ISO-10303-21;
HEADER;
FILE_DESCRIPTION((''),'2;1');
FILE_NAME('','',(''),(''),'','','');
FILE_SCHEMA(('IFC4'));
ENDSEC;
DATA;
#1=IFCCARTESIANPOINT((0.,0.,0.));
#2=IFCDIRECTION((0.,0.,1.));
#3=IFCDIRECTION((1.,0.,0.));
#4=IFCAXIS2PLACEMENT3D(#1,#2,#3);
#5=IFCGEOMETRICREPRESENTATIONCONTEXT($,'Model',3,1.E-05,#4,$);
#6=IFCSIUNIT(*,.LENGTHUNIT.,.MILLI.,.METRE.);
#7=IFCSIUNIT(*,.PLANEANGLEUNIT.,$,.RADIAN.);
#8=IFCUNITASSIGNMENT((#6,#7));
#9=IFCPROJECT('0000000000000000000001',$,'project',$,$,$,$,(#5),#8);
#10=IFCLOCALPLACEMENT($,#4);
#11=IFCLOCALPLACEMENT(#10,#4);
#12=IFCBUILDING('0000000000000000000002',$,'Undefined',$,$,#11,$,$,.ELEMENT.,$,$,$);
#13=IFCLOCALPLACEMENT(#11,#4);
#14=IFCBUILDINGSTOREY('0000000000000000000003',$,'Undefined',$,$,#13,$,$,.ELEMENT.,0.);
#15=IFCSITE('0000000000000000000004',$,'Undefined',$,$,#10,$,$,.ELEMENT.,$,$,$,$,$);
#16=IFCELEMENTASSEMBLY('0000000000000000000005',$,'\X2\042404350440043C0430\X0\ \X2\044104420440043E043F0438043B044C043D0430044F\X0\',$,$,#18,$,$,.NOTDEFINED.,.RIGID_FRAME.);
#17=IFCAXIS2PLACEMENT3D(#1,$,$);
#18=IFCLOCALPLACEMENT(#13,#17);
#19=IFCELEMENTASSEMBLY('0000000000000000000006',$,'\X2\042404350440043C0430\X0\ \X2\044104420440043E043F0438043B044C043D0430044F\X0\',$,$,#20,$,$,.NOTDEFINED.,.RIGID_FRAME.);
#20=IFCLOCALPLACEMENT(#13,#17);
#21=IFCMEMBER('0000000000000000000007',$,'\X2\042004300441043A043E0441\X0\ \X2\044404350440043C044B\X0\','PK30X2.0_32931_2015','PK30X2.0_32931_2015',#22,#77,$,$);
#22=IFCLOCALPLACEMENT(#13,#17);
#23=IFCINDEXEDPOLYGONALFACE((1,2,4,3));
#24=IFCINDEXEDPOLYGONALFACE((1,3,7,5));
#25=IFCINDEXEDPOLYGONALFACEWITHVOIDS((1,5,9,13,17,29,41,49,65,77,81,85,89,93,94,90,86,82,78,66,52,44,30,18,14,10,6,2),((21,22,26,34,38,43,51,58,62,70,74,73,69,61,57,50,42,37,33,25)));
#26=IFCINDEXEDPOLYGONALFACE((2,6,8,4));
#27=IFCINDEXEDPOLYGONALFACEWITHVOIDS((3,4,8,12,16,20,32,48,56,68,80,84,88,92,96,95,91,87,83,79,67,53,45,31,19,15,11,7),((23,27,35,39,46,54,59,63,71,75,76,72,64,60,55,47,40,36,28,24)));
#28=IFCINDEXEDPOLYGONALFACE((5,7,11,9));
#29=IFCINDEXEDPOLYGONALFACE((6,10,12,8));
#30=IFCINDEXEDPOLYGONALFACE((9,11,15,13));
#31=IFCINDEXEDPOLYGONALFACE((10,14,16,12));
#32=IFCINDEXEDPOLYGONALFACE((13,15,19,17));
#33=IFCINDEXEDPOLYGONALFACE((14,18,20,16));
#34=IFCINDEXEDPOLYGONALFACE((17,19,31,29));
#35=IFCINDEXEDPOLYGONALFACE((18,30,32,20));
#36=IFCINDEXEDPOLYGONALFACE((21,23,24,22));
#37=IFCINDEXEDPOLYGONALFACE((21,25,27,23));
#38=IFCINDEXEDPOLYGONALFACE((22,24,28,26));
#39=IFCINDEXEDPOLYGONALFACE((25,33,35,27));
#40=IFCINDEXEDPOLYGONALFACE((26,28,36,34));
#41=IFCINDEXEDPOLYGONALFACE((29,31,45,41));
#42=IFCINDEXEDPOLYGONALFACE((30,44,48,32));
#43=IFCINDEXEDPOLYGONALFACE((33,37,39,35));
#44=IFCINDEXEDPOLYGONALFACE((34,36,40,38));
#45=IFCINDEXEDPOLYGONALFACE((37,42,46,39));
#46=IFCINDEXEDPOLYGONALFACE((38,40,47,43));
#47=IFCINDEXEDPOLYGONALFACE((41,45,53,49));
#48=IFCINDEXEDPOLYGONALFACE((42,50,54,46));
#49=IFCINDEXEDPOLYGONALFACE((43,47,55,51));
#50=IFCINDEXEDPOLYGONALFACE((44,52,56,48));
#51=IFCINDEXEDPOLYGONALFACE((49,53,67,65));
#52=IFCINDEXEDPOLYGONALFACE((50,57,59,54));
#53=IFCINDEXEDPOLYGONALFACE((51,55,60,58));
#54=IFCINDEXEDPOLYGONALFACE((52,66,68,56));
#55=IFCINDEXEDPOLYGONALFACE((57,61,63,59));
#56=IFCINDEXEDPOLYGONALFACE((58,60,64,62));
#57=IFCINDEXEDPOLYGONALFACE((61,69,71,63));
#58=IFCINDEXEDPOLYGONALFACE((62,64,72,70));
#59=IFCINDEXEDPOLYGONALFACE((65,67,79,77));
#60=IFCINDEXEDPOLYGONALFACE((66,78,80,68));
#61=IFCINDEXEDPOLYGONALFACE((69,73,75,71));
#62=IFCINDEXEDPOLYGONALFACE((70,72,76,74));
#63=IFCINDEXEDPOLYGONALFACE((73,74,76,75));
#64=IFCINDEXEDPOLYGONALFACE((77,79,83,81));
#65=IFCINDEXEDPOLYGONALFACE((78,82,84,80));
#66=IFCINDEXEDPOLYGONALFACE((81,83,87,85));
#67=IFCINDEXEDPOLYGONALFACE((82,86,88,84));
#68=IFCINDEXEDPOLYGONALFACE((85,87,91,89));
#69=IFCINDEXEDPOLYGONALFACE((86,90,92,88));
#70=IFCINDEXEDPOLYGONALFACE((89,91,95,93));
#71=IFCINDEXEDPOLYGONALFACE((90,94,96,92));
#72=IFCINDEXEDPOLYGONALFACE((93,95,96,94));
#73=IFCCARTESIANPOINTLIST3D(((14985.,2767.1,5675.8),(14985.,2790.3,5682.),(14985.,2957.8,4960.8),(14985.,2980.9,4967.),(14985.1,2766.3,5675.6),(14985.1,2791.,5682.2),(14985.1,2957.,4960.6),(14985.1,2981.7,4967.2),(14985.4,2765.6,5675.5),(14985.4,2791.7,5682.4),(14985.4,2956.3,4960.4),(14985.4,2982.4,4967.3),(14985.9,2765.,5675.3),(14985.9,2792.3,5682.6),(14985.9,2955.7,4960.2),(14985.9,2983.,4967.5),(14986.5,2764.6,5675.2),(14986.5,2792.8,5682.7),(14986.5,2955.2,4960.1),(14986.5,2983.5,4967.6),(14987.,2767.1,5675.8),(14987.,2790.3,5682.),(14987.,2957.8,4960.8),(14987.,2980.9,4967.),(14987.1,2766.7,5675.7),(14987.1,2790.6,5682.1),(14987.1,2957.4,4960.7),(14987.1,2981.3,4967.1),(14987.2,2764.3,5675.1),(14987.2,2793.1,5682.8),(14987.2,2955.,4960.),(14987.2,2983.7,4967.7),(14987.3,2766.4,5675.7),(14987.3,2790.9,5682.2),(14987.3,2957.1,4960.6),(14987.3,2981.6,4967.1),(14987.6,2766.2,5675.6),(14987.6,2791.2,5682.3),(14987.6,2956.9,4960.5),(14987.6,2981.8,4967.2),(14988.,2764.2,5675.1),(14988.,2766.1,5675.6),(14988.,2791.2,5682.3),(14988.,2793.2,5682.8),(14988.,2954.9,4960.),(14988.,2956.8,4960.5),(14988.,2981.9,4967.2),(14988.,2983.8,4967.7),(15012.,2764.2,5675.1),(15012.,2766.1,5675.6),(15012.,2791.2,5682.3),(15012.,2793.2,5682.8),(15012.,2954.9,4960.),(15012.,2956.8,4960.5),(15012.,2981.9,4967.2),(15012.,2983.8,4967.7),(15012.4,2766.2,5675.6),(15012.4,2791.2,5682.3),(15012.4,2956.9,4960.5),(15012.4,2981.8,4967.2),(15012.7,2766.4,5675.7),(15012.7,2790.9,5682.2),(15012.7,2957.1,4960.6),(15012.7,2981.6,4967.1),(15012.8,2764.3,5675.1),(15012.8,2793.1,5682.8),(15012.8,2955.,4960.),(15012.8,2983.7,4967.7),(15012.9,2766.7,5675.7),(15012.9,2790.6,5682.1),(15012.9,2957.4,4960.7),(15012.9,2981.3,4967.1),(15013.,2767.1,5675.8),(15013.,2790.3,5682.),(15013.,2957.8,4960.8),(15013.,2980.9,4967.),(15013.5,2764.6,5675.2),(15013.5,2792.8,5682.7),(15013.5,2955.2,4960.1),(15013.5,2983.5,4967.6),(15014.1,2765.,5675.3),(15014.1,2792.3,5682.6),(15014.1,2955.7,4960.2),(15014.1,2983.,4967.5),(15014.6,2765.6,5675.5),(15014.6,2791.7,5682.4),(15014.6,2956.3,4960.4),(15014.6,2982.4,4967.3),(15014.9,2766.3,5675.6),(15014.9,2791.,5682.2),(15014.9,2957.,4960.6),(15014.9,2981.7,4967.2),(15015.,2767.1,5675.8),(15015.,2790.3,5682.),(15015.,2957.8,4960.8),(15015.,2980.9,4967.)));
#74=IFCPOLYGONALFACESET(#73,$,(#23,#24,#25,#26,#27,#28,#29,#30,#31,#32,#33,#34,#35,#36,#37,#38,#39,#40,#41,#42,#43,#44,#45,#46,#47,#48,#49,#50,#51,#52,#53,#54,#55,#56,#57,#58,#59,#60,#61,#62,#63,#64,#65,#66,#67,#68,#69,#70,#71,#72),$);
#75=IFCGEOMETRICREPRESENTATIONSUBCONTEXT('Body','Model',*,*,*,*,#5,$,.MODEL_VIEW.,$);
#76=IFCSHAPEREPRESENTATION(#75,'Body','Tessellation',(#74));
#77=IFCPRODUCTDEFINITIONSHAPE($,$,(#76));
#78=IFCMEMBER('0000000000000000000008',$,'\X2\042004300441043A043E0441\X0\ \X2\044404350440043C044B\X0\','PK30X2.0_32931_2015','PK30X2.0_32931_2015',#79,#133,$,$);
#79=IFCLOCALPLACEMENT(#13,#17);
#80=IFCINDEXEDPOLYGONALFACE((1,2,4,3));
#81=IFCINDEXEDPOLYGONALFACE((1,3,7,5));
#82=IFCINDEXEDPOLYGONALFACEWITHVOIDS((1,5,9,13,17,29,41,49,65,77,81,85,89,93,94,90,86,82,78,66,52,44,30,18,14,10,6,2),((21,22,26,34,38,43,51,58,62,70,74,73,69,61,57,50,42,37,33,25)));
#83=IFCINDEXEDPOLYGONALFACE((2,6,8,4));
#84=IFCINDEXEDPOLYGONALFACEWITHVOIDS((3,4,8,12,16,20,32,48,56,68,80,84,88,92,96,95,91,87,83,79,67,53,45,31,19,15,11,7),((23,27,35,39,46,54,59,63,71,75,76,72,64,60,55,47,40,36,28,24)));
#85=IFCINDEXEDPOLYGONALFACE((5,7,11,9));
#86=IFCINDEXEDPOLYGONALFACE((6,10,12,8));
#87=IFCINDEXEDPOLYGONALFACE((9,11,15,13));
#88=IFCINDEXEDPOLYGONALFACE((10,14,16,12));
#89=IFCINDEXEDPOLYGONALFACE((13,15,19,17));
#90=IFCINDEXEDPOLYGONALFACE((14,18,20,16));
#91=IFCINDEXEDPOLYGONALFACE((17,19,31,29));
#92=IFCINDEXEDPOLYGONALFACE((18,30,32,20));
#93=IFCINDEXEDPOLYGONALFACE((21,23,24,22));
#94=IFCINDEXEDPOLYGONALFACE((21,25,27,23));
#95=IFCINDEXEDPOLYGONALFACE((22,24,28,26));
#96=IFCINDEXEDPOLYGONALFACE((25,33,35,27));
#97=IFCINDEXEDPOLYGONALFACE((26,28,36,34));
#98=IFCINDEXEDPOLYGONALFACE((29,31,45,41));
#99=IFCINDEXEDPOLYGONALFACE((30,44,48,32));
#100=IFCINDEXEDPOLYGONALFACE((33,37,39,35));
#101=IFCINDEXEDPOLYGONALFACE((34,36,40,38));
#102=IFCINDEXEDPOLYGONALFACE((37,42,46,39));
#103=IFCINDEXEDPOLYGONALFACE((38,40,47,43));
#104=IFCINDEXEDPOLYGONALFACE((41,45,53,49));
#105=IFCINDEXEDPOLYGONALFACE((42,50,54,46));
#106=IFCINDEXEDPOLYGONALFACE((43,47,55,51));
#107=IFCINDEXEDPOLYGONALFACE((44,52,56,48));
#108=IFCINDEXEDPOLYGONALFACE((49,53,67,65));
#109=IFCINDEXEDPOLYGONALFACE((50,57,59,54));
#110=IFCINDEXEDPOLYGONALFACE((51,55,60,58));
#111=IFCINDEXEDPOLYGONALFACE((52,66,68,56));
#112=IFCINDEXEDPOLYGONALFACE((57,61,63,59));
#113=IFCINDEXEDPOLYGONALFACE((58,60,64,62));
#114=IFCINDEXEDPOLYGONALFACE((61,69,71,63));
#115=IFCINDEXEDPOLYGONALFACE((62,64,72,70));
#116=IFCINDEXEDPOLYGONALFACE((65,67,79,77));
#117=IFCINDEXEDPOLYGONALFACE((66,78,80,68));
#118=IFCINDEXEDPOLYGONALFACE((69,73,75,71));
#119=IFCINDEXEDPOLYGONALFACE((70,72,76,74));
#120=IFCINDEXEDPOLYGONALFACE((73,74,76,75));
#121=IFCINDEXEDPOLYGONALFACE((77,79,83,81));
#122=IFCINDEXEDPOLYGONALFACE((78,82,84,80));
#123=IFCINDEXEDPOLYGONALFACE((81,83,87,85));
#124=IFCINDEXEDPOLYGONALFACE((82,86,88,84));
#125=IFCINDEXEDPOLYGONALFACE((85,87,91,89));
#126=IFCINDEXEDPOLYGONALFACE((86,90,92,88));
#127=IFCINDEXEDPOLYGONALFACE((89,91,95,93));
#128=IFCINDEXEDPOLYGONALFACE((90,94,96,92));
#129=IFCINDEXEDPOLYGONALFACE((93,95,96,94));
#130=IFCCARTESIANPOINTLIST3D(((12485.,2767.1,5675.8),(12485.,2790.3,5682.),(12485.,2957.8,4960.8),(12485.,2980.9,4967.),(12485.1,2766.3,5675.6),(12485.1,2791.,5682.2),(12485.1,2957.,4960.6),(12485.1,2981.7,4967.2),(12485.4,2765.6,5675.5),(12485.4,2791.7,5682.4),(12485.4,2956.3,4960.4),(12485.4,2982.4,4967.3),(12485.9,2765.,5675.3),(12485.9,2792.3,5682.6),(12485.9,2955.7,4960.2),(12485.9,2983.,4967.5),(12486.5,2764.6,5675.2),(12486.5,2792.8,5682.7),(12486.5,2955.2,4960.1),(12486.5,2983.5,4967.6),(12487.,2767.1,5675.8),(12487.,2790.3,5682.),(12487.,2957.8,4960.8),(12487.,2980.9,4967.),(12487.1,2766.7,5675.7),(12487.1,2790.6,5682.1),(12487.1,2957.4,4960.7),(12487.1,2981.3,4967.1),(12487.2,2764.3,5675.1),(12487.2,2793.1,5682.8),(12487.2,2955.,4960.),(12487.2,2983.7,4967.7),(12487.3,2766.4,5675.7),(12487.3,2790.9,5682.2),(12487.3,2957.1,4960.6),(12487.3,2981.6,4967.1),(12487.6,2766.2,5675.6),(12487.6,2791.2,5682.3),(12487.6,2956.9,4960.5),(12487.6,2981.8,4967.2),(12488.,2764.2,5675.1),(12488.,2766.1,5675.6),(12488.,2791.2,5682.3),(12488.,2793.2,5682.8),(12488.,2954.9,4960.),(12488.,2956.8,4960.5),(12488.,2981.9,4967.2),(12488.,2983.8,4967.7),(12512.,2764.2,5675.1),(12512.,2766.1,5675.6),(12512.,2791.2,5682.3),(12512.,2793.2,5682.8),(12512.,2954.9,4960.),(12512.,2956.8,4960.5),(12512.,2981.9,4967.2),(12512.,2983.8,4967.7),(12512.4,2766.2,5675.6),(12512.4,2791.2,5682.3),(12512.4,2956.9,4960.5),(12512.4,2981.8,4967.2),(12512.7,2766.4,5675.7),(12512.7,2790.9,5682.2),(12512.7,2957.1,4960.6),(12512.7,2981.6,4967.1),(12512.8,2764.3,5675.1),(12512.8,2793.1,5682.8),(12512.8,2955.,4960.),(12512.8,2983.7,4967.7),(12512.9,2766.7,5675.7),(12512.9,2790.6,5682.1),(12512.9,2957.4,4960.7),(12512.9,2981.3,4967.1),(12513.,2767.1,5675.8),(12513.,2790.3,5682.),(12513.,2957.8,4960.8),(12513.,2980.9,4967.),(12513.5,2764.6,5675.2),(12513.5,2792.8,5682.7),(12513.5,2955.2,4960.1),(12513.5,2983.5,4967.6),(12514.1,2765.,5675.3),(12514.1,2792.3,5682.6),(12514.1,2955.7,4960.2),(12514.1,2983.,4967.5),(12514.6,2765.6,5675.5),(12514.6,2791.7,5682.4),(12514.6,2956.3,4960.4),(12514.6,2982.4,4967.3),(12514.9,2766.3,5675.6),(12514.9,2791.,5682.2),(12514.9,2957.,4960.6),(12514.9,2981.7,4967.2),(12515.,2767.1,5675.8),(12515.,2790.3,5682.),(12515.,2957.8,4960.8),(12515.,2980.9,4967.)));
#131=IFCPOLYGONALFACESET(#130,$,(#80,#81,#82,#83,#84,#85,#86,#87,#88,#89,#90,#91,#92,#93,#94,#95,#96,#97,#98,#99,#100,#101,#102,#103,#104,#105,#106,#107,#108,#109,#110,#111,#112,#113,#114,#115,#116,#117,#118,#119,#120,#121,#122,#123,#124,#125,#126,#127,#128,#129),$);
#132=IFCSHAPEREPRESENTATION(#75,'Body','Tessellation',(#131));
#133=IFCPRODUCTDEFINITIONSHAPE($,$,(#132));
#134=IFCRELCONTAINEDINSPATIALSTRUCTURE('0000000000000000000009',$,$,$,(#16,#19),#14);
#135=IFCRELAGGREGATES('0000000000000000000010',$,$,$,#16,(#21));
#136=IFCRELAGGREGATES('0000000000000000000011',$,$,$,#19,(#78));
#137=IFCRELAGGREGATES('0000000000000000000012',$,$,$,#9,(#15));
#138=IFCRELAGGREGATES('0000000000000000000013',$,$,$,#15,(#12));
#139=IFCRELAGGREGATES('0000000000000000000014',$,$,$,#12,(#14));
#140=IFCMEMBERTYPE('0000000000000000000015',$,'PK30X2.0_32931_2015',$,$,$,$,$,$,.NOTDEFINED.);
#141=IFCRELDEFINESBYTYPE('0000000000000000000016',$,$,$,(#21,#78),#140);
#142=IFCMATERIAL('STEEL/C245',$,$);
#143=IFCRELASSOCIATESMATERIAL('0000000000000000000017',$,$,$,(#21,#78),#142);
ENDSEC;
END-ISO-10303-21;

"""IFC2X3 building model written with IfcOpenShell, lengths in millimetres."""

from ifc_helpers import new_model, si_unit, frame, origin_with_axes, origin_2d_with_axis, place, context, subcontext, project, spatial, hollow_rectangle, extrude, material, type_object, element, aggregate, save


model = new_model("IFC2X3")

# Units and contexts
model_context = context("Model", 3, precision=1e-05, world=origin_with_axes())
body_context = subcontext(model_context, "Body", "Model", "MODEL_VIEW")
ifc_project = project(units=[si_unit("LENGTHUNIT", "METRE", prefix="MILLI"), si_unit("PLANEANGLEUNIT", "RADIAN")], contexts=[model_context])

# Site, building, storey
site_placement = place(None, origin_with_axes())
site = spatial("IfcSite", under=ifc_project, at=site_placement, Name="Undefined", CompositionType="ELEMENT")
building_placement = place(site_placement, origin_with_axes())
building = spatial("IfcBuilding", under=site, at=building_placement, Name="Undefined", CompositionType="ELEMENT")
storey_placement = place(building_placement, origin_with_axes())
storey = spatial("IfcBuildingStorey", under=building, at=storey_placement, Name="Undefined", CompositionType="ELEMENT", Elevation=0.0)

# Shared definitions
ifc_material_1 = material(Name="STEEL/C245")

# Element assemblies
assembly_1_placement = place(storey_placement, origin_with_axes())
assembly_1 = element("IfcElementAssembly", 1, at=assembly_1_placement, inside=storey, Name="Ферма стропильная", AssemblyPlace="NOTDEFINED", PredefinedType="RIGID_FRAME")
assembly_2_placement = place(storey_placement, origin_with_axes())
assembly_2 = element("IfcElementAssembly", 2, at=assembly_2_placement, inside=storey, Name="Ферма стропильная", AssemblyPlace="NOTDEFINED", PredefinedType="RIGID_FRAME")

# Members
member_type_1 = type_object("IfcMemberType", Name="PK30X2.0_32931_2015", PredefinedType="NOTDEFINED")
member_1_placement = place(assembly_1_placement, frame((15000.0, 2778.7, 5678.9), z_axis=(0.0, -0.966235, -0.257663), x_axis=(0.0, 0.257663, -0.966235)))
member_1 = element("IfcMember", 3, at=member_1_placement, type_object=member_type_1, material=ifc_material_1, Name="Раскос фермы", Description="PK30X2.0_32931_2015", ObjectType="PK30X2.0_32931_2015", context=body_context, shape_type="SweptSolid", body=[
    extrude(hollow_rectangle(XDim=30.0, YDim=30.0, WallThickness=2.0, InnerFilletRadius=1.0, OuterFilletRadius=3.0, at=origin_2d_with_axis()), frame((740.0, 0.0, 0.0), z_axis=(-1.0, 0.0, 0.0), x_axis=(0.0, -1.0, 0.0)), (0.0, 0.0, 1.0), 740.0),
])
aggregate(assembly_1, [member_1])
member_2_placement = place(assembly_2_placement, frame((12500.0, 2778.7, 5678.9), z_axis=(0.0, -0.966235, -0.257663), x_axis=(0.0, 0.257663, -0.966235)))
member_2 = element("IfcMember", 4, at=member_2_placement, type_object=member_type_1, material=ifc_material_1, Name="Раскос фермы", Description="PK30X2.0_32931_2015", ObjectType="PK30X2.0_32931_2015", context=body_context, shape_type="SweptSolid", body=[
    extrude(hollow_rectangle(XDim=30.0, YDim=30.0, WallThickness=2.0, InnerFilletRadius=1.0, OuterFilletRadius=3.0, at=origin_2d_with_axis()), frame((740.0, 0.0, 0.0), z_axis=(-1.0, 0.0, 0.0), x_axis=(0.0, -1.0, 0.0)), (0.0, 0.0, 1.0), 740.0),
])
aggregate(assembly_2, [member_2])

save(model, "model.ifc")
